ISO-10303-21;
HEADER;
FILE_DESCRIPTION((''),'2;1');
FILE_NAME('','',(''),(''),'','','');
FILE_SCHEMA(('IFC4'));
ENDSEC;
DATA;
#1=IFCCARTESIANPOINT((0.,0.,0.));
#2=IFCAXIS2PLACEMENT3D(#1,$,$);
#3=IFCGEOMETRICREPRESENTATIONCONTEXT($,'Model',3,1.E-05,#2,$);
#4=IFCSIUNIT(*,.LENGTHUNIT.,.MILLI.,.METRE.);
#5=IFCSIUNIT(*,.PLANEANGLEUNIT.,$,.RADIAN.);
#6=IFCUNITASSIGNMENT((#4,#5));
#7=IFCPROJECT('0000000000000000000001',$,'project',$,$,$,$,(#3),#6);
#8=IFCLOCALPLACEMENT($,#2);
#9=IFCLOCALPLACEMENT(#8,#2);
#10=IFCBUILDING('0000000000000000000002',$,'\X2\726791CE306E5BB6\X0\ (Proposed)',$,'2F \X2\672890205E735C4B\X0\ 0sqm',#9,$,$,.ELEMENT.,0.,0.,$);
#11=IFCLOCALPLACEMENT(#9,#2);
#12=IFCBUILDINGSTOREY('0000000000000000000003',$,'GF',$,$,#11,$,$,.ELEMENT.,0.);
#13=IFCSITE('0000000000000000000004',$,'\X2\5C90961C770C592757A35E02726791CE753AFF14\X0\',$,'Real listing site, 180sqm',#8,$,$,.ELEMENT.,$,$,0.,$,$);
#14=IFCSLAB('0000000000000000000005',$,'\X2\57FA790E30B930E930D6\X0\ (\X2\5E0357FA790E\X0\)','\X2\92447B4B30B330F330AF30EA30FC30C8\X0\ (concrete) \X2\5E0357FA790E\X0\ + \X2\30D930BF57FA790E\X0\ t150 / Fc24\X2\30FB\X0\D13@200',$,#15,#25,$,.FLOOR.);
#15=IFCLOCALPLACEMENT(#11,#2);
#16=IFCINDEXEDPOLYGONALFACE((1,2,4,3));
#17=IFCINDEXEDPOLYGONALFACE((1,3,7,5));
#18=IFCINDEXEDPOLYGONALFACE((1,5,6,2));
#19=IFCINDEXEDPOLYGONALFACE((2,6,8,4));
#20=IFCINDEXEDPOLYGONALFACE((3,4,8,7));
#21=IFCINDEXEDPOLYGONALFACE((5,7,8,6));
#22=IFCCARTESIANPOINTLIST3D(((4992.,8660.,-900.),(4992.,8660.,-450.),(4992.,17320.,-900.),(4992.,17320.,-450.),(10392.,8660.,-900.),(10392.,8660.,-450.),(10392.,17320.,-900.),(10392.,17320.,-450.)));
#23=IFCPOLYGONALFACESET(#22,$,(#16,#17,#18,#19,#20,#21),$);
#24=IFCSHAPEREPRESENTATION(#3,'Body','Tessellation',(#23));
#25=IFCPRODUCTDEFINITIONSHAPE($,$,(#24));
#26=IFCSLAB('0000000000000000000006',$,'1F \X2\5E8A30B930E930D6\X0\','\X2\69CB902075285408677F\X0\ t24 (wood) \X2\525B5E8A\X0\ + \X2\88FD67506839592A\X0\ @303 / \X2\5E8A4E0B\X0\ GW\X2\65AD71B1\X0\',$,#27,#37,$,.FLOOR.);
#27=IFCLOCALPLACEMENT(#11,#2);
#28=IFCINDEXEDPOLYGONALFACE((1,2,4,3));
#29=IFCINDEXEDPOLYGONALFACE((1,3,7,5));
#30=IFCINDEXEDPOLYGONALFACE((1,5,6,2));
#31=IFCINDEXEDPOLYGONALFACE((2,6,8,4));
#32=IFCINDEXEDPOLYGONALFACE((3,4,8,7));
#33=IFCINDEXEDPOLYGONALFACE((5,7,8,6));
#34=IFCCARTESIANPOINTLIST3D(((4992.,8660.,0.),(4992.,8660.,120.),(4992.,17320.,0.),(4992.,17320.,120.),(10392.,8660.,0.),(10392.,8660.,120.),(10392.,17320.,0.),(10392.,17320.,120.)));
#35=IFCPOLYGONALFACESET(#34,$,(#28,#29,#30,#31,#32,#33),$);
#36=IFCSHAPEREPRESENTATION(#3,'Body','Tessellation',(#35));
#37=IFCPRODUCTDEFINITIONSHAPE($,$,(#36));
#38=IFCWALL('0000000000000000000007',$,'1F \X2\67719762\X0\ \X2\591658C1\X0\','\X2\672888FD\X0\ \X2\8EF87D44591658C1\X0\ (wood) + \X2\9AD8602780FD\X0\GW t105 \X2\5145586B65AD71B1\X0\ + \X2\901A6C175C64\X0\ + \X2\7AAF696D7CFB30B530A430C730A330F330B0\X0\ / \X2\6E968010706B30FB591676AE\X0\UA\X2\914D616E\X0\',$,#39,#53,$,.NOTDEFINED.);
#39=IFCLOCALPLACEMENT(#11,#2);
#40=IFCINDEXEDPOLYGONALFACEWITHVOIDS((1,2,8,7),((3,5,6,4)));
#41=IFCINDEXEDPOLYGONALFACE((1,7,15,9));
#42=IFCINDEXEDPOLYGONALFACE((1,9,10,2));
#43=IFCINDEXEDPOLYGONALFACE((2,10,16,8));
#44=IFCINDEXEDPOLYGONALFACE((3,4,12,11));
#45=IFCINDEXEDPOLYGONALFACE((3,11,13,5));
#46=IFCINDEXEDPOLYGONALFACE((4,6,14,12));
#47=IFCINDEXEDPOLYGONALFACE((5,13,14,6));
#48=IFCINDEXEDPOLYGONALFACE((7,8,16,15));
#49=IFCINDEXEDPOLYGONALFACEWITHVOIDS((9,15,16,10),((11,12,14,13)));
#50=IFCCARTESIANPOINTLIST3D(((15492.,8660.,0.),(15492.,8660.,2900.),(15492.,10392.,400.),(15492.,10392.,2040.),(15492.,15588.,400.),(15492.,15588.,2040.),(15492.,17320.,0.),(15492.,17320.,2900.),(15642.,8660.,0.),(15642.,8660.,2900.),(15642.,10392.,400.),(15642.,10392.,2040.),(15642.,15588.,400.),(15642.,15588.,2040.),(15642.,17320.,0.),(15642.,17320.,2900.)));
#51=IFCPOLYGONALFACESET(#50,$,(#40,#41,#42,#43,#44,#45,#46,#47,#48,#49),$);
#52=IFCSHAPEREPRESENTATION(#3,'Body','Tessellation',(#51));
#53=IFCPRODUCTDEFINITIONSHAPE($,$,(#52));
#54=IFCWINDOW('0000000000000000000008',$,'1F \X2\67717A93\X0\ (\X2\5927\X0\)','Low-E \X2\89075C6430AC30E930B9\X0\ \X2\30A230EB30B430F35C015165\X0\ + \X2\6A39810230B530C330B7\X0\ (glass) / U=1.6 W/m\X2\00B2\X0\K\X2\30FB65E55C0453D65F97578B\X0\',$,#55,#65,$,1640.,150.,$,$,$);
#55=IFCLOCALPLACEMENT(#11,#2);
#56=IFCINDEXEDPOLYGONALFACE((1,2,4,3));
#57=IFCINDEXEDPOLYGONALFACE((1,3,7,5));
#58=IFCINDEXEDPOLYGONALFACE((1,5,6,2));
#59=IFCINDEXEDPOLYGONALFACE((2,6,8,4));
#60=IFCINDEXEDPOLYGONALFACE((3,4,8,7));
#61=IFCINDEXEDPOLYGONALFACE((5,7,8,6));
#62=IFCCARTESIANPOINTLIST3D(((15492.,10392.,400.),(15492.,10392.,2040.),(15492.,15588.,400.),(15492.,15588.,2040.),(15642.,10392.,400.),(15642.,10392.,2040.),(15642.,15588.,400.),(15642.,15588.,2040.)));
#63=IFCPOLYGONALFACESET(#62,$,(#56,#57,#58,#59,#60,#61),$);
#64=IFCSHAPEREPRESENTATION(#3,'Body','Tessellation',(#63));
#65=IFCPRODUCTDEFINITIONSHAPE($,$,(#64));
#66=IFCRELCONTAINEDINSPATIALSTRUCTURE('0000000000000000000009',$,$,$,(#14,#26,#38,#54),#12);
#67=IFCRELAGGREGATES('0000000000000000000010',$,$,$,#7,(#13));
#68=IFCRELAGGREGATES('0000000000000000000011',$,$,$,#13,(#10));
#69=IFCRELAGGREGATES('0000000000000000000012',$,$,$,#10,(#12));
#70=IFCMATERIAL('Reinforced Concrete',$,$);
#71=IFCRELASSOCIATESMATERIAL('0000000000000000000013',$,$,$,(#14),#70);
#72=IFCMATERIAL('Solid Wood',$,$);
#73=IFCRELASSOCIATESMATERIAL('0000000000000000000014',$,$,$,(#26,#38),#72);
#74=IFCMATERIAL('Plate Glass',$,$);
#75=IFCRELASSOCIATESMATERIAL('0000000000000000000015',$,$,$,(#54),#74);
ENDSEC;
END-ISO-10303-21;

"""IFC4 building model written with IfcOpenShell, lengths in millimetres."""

from ifc_helpers import new_model, si_unit, frame, frame_2d, origin, place, context, project, spatial, rectangle, extrude, material, element, fill, save


model = new_model("IFC4")

# Units and contexts
model_context = context("Model", 3, precision=1e-05, world=origin())
ifc_project = project(units=[si_unit("LENGTHUNIT", "METRE", prefix="MILLI"), si_unit("PLANEANGLEUNIT", "RADIAN")], contexts=[model_context])

# Site, building, storey
site_placement = place(None, origin())
site = spatial("IfcSite", under=ifc_project, at=site_placement, Name="岐阜県大垣市牧野町４", ObjectType="Real listing site, 180sqm", CompositionType="ELEMENT", RefElevation=0.0)
building_placement = place(site_placement, origin())
building = spatial("IfcBuilding", under=site, at=building_placement, Name="牧野の家 (Proposed)", ObjectType="2F 木造平屋 0sqm", CompositionType="ELEMENT", ElevationOfRefHeight=0.0, ElevationOfTerrain=0.0)
storey_placement = place(building_placement, origin())
storey = spatial("IfcBuildingStorey", under=building, at=storey_placement, Name="GF", CompositionType="ELEMENT", Elevation=0.0)

# Slabs
ifc_material_1 = material(Name="Reinforced Concrete")
slab_1_placement = place(storey_placement, frame((2496.0, 4330.0, -450.0)))
element("IfcSlab", 1, at=slab_1_placement, inside=storey, material=ifc_material_1, Name="基礎スラブ (布基礎)", Description="鉄筋コンクリート (concrete) 布基礎 + ベタ基礎 t150 / Fc24・D13@200", PredefinedType="FLOOR", context=model_context, shape_type="SweptSolid", body=[
    extrude(rectangle(XDim=5400.0, YDim=8660.0, at=frame_2d((2700.0, 4330.0))), frame((2496.0, 4330.0, -450.0)), (0.0, 0.0, 1.0), 450.0),
])
ifc_material_2 = material(Name="Solid Wood")
slab_2_placement = place(storey_placement, frame((2496.0, 4330.0, 0.0)))
element("IfcSlab", 2, at=slab_2_placement, inside=storey, material=ifc_material_2, Name="1F 床スラブ", Description="構造用合板 t24 (wood) 剛床 + 製材根太 @303 / 床下 GW断熱", PredefinedType="FLOOR", context=model_context, shape_type="SweptSolid", body=[
    extrude(rectangle(XDim=5400.0, YDim=8660.0, at=frame_2d((2700.0, 4330.0))), frame((2496.0, 4330.0, 0.0)), (0.0, 0.0, 1.0), 120.0),
])

# Shared definitions
ifc_material_3 = material(Name="Plate Glass")

# Wall, opening, window
wall_1_placement = place(storey_placement, frame((7746.0, 4330.0, 0.0)))
wall_1 = element("IfcWall", 3, at=wall_1_placement, inside=storey, material=ifc_material_2, Name="1F 東面 外壁", Description="木製 軸組外壁 (wood) + 高性能GW t105 充填断熱 + 通気層 + 窯業系サイディング / 準耐火・外皮UA配慮", PredefinedType="NOTDEFINED", context=model_context, shape_type="SweptSolid", body=[
    extrude(rectangle(XDim=150.0, YDim=8660.0, at=frame_2d((75.0, 4330.0))), frame((7746.0, 4330.0, 0.0)), (0.0, 0.0, 1.0), 2900.0),
])
opening_1_placement = place(storey_placement, frame((7746.0, 5196.0, 200.0)))
opening_1 = element("IfcOpeningElement", 4, at=opening_1_placement, cuts=wall_1, PredefinedType="NOTDEFINED", context=model_context, shape_type="SweptSolid", body=[
    extrude(rectangle(XDim=150.0, YDim=5196.0, at=frame_2d((75.0, 2598.0))), frame((7746.0, 5196.0, 200.0)), (0.0, 0.0, 1.0), 1640.0),
])
window_1_placement = place(storey_placement, frame((7746.0, 5196.0, 200.0)))
window_1 = element("IfcWindow", 5, at=window_1_placement, inside=storey, material=ifc_material_3, Name="1F 東窓 (大)", Description="Low-E 複層ガラス アルゴン封入 + 樹脂サッシ (glass) / U=1.6 W/m²K・日射取得型", OverallHeight=1640.0, OverallWidth=150.0, context=model_context, shape_type="SweptSolid", body=[
    extrude(rectangle(XDim=150.0, YDim=5196.0, at=frame_2d((75.0, 2598.0))), frame((7746.0, 5196.0, 200.0)), (0.0, 0.0, 1.0), 1640.0),
])
fill(opening_1, window_1)

save(model, "model.ifc")
